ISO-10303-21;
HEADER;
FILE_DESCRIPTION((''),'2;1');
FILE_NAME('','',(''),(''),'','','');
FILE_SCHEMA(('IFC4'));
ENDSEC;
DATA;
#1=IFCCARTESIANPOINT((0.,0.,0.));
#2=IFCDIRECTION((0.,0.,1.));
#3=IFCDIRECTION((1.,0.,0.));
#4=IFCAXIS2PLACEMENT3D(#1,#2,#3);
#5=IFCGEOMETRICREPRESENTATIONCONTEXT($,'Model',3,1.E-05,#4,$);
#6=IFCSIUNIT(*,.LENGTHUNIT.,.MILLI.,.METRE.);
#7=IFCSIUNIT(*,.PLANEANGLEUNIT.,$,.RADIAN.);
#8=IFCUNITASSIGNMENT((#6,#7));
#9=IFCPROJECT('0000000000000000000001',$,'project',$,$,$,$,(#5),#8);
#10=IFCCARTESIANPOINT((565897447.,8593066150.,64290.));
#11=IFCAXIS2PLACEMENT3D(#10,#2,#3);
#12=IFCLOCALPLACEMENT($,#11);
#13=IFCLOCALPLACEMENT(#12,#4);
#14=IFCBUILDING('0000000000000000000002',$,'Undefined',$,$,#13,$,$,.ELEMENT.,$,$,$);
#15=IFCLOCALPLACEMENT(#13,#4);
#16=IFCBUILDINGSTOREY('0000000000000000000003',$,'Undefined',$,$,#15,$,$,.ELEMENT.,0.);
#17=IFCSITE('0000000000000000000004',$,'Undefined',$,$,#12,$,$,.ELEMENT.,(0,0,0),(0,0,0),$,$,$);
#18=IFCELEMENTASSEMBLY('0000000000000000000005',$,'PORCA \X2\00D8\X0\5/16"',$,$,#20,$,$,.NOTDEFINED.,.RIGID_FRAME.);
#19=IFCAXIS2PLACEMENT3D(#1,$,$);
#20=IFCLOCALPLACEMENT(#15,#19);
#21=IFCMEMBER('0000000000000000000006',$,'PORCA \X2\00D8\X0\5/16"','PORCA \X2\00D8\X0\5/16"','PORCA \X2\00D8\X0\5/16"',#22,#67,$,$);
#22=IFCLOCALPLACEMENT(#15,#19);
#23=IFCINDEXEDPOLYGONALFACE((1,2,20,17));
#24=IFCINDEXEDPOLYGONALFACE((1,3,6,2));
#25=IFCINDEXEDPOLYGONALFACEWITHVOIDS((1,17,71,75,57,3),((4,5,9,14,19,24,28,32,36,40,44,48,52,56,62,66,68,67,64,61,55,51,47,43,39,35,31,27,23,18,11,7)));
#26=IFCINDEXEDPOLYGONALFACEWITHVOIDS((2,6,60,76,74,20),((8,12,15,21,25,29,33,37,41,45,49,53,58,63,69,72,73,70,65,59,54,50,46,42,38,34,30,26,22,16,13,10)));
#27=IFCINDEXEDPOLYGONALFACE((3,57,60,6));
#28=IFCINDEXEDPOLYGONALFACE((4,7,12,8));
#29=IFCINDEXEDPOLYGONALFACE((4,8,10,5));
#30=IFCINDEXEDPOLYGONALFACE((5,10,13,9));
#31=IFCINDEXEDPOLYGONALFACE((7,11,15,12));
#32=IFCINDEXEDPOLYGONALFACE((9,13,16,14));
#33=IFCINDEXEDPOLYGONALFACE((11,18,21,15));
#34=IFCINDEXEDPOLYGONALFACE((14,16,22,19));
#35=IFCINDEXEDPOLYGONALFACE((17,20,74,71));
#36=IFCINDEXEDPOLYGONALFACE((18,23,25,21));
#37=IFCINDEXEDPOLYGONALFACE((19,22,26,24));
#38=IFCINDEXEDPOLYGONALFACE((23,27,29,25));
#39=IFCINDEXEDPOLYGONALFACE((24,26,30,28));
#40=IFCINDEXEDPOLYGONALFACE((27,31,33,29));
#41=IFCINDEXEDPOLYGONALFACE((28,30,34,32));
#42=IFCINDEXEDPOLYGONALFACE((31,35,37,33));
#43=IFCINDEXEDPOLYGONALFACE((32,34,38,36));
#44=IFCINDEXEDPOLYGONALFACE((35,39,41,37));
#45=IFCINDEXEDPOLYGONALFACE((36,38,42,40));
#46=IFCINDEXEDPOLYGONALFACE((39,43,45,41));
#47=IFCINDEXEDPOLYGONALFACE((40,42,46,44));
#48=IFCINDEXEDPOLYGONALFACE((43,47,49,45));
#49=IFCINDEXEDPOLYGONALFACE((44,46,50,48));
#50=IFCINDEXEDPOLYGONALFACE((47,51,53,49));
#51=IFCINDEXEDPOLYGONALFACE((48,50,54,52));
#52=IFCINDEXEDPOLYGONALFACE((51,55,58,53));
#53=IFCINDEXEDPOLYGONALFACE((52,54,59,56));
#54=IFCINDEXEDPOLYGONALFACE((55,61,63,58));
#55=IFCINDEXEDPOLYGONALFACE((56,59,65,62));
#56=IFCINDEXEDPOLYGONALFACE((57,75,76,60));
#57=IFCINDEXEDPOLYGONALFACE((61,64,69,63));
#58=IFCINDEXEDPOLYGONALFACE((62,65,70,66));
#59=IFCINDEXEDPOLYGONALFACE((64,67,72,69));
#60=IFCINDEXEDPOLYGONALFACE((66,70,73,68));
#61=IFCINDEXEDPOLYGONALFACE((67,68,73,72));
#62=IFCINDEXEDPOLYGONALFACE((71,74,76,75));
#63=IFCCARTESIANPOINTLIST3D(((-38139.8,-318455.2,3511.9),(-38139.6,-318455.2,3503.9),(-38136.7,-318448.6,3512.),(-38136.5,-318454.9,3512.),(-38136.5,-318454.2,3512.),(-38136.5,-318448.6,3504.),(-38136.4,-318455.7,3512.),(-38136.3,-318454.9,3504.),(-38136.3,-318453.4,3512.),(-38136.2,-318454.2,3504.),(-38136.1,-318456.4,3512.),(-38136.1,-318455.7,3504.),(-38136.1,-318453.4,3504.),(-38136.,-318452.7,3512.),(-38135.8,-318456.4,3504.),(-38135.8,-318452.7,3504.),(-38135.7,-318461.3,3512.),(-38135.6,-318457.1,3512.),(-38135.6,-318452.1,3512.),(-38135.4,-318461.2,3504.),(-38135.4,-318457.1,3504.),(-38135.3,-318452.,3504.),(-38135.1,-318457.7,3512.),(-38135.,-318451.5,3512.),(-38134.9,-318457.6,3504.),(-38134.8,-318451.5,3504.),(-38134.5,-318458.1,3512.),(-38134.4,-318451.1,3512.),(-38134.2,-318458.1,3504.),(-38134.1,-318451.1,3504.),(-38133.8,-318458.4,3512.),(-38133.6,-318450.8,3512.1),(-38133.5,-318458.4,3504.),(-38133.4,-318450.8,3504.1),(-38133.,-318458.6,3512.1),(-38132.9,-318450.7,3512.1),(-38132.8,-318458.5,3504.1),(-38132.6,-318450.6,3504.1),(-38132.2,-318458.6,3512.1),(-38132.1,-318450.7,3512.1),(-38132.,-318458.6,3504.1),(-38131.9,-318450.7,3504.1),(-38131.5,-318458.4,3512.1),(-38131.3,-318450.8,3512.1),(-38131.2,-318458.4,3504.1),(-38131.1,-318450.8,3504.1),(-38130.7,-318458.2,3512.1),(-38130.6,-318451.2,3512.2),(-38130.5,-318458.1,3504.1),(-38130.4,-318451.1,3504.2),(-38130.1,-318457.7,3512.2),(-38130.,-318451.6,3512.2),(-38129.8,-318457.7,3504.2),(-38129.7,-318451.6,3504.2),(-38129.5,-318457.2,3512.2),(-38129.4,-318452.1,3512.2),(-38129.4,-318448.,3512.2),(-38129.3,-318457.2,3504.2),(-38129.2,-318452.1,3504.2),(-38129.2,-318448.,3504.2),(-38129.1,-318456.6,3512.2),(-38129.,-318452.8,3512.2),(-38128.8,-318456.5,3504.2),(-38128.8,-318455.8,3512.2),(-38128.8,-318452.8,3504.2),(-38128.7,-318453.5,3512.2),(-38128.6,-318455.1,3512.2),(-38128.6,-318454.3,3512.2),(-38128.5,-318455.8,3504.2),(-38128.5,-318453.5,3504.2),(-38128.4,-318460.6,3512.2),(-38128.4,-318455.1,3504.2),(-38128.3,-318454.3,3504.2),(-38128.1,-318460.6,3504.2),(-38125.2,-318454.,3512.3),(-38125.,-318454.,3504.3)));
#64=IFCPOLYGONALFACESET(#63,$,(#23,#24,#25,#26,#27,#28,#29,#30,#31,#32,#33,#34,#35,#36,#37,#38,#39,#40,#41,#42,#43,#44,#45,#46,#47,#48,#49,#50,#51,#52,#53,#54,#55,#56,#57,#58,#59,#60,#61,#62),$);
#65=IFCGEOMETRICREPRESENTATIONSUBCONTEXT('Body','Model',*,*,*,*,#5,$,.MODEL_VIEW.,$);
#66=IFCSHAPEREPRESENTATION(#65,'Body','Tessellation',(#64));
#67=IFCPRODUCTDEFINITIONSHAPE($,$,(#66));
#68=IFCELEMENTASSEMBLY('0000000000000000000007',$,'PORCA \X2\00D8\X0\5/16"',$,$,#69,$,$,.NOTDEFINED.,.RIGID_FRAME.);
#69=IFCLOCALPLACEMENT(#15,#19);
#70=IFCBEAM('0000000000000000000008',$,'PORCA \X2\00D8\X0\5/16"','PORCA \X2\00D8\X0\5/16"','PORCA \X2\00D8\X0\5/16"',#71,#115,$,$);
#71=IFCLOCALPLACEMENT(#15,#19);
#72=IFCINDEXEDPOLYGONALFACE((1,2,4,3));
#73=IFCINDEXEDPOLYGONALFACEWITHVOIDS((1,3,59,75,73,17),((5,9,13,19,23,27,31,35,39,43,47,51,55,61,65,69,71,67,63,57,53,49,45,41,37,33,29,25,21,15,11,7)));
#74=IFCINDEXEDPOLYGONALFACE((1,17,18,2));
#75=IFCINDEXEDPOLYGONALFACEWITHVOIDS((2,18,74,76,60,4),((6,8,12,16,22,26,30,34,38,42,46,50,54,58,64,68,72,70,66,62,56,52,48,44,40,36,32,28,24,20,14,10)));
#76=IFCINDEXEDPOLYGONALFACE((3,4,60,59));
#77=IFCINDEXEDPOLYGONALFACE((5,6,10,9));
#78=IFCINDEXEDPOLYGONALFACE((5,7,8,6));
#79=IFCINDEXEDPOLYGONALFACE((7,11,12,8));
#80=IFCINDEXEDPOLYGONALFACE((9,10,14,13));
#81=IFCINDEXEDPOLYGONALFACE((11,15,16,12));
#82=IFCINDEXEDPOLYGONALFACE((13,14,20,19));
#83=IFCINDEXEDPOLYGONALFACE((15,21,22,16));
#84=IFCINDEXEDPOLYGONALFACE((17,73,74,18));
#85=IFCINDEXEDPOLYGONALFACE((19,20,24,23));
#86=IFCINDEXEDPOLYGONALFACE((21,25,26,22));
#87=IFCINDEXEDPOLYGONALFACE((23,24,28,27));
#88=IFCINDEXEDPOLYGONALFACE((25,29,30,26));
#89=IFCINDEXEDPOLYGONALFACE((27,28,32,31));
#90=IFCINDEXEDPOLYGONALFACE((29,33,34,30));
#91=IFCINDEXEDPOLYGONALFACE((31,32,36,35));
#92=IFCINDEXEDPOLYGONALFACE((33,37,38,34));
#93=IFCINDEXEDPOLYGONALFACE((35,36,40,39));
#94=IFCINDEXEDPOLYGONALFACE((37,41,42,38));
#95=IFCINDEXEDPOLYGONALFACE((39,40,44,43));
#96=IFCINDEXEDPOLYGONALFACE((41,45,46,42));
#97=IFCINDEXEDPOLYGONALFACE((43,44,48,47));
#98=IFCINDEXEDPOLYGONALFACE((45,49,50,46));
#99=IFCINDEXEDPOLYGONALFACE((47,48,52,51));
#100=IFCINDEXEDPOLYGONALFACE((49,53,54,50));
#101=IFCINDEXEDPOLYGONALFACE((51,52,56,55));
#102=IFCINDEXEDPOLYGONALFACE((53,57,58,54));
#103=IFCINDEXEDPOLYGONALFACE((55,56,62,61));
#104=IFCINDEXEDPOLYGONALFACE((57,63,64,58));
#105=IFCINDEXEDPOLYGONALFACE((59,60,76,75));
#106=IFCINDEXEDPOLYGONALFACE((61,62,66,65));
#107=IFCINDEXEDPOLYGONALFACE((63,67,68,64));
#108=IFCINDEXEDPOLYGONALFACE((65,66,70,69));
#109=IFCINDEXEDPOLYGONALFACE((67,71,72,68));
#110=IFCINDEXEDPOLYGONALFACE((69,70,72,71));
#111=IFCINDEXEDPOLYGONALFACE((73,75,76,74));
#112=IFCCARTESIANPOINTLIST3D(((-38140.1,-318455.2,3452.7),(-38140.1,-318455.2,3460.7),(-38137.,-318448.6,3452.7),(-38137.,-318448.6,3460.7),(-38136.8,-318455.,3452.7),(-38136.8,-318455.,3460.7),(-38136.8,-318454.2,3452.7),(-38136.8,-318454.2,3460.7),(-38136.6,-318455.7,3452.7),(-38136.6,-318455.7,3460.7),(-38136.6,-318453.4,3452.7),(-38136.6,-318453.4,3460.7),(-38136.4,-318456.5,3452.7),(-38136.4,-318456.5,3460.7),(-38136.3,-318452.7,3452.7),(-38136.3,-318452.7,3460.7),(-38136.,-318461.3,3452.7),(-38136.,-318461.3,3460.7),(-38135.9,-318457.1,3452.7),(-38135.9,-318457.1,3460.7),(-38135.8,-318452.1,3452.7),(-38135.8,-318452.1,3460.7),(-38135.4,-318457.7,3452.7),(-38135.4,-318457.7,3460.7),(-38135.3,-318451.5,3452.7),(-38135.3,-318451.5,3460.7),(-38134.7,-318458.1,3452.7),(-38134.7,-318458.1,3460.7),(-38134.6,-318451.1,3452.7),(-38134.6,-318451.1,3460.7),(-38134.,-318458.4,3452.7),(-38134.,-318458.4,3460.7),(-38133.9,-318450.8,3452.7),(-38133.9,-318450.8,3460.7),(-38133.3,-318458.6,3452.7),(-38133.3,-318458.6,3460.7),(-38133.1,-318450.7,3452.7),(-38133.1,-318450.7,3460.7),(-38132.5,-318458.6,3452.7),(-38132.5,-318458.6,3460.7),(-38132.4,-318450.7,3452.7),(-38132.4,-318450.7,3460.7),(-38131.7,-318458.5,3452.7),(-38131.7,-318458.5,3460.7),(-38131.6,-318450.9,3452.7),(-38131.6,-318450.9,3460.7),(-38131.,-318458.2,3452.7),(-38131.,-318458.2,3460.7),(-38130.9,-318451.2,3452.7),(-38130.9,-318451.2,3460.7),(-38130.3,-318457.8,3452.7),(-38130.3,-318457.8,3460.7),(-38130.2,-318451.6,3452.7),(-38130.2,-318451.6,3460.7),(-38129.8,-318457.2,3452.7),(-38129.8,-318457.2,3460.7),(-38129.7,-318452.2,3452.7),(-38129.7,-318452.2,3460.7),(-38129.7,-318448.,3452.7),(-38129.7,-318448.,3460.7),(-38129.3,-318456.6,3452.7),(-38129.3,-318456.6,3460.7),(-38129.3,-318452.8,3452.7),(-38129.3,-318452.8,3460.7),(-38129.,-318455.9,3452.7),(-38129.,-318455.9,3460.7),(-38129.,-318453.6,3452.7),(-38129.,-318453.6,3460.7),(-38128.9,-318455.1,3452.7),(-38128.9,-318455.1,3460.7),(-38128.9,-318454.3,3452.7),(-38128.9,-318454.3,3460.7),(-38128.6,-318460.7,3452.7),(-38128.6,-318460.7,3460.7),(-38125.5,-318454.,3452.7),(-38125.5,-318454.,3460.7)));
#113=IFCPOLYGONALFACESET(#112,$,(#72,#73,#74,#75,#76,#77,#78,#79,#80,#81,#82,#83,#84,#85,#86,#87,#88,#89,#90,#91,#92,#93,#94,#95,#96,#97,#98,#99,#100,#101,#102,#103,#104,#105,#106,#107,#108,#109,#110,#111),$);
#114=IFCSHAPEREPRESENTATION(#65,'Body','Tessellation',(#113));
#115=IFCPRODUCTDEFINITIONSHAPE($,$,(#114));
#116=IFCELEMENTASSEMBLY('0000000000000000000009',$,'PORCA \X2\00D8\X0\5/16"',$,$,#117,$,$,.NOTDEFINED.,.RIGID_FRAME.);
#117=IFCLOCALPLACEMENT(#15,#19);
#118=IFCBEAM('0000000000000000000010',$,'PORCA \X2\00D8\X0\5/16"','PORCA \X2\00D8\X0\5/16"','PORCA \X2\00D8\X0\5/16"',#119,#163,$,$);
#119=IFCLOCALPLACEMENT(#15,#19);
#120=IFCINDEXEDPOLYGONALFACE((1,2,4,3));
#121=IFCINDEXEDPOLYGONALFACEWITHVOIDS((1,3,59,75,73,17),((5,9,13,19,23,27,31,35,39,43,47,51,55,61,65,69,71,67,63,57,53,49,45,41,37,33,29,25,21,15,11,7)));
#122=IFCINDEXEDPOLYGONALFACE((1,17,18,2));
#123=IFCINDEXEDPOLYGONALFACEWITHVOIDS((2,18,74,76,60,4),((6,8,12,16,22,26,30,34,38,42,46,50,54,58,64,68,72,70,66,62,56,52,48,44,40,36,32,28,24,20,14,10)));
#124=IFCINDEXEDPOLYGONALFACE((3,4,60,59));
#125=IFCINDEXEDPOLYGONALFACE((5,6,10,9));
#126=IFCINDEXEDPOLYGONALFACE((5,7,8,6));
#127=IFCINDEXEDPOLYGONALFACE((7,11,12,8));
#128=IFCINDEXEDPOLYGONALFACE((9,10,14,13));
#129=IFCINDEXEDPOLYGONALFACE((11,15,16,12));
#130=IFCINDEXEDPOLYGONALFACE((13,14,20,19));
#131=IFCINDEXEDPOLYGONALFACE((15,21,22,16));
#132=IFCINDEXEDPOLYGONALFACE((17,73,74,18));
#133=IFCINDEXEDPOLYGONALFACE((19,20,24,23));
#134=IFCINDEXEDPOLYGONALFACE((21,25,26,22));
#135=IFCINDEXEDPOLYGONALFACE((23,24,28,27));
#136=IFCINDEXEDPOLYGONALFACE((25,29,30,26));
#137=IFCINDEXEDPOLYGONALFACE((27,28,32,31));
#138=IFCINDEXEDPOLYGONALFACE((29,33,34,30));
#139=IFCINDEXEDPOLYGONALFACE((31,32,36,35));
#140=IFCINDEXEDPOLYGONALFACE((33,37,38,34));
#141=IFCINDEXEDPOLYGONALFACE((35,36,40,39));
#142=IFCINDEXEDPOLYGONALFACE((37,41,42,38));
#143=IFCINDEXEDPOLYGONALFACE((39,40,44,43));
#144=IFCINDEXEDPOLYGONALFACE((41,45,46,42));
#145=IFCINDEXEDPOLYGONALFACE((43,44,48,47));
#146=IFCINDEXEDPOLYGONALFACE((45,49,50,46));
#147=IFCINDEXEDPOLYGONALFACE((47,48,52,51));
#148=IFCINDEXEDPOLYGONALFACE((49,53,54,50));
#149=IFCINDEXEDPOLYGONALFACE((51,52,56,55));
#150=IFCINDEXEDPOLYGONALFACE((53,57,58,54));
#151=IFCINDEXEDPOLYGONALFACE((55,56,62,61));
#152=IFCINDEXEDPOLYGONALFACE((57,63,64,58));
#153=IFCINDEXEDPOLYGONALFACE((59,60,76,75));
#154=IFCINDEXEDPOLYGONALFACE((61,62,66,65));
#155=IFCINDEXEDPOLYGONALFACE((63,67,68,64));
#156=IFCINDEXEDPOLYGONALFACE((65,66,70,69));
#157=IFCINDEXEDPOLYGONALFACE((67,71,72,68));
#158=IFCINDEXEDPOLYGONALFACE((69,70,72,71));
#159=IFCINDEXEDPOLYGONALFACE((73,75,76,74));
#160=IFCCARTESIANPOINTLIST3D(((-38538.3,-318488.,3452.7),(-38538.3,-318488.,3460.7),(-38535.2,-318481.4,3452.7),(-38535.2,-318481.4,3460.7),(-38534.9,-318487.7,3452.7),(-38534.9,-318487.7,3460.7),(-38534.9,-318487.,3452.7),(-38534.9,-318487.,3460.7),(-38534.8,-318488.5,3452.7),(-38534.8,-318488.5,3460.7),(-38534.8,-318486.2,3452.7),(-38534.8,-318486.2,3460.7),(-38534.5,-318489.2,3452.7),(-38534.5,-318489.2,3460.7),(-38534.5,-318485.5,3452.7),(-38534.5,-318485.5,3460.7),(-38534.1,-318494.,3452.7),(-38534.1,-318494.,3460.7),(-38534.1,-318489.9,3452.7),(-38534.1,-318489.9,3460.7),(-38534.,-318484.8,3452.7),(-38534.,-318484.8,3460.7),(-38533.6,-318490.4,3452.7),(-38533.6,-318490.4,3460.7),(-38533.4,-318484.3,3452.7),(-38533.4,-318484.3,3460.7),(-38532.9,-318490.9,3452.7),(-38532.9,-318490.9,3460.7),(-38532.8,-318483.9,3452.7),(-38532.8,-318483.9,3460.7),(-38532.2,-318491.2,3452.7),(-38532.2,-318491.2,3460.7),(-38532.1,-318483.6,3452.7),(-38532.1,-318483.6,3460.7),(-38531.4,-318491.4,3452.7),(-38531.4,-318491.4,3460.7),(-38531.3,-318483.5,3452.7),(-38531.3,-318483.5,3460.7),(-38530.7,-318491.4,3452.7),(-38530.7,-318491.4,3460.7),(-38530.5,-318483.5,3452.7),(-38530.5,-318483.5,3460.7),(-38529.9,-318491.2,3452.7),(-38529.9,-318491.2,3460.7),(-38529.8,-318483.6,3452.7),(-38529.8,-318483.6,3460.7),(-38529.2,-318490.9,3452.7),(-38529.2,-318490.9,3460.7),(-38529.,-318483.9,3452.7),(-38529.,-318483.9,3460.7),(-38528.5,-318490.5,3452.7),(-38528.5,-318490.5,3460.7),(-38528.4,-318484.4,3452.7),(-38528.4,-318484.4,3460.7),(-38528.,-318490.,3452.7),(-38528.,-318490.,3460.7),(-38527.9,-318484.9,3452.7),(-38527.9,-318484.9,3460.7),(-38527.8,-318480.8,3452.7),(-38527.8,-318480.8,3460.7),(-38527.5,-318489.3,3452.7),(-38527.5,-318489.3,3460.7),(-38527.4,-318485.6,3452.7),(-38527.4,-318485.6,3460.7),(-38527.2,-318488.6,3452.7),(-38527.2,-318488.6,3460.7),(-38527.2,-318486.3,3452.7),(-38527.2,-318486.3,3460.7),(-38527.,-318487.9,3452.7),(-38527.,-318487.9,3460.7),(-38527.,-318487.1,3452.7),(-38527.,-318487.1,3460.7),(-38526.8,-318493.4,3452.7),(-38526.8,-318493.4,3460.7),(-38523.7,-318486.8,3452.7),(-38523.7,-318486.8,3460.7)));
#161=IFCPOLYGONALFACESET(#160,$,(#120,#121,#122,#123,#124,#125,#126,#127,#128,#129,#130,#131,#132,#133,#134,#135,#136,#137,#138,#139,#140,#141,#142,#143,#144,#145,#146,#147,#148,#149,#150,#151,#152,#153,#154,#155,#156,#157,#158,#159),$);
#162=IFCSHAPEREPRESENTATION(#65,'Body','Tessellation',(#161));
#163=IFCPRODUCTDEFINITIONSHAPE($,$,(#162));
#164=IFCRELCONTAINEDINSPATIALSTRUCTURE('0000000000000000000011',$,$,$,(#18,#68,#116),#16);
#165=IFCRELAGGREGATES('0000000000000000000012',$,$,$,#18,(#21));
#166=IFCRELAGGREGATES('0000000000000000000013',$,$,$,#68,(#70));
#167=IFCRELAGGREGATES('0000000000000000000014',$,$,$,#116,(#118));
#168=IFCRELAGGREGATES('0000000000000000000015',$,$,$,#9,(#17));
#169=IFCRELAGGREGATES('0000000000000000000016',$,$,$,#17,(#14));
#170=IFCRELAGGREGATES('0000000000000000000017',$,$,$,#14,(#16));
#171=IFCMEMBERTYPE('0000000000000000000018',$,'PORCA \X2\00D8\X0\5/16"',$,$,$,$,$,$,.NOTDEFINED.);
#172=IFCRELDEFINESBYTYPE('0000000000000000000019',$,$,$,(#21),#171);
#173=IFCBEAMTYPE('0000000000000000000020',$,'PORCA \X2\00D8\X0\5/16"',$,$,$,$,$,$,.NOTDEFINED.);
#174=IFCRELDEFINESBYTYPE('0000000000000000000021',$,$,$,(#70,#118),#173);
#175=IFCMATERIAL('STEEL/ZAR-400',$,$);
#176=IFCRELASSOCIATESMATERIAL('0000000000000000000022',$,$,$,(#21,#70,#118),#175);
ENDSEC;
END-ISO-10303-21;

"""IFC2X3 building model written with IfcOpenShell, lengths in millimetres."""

from ifc_helpers import new_model, si_unit, frame, origin_with_axes, place, context, subcontext, project, spatial, polyline, outline, extrude, material, type_object, element, aggregate, save


model = new_model("IFC2X3")

# Units and contexts
model_context = context("Model", 3, precision=1e-05, world=origin_with_axes())
body_context = subcontext(model_context, "Body", "Model", "MODEL_VIEW")
ifc_project = project(units=[si_unit("LENGTHUNIT", "METRE", prefix="MILLI"), si_unit("PLANEANGLEUNIT", "RADIAN")], contexts=[model_context])

# Site, building, storey
site_placement = place(None, frame((565897447.0, 8593066150.0, 64290.0), z_axis=(0.0, 0.0, 1.0), x_axis=(1.0, 0.0, 0.0)))
site = spatial("IfcSite", under=ifc_project, at=site_placement, Name="Undefined", CompositionType="ELEMENT", RefLatitude=(0, 0, 0), RefLongitude=(0, 0, 0))
building_placement = place(site_placement, origin_with_axes())
building = spatial("IfcBuilding", under=site, at=building_placement, Name="Undefined", CompositionType="ELEMENT")
storey_placement = place(building_placement, origin_with_axes())
storey = spatial("IfcBuildingStorey", under=building, at=storey_placement, Name="Undefined", CompositionType="ELEMENT", Elevation=0.0)

# Element assembly, member
assembly_1_placement = place(storey_placement, origin_with_axes())
assembly_1 = element("IfcElementAssembly", 1, at=assembly_1_placement, inside=storey, Name="PORCA Ø5/16\"", AssemblyPlace="NOTDEFINED", PredefinedType="RIGID_FRAME")
ifc_material_1 = material(Name="STEEL/ZAR-400")
member_type = type_object("IfcMemberType", Name="PORCA Ø5/16\"", PredefinedType="NOTDEFINED")
member_placement = place(assembly_1_placement, frame((-38134.3, -318454.8, 3512.0), z_axis=(-0.082025, 0.99663, 0.0), x_axis=(0.029566, 0.002433, -0.99956)))
member = element("IfcMember", 2, at=member_placement, type_object=member_type, material=ifc_material_1, Name="PORCA Ø5/16\"", Description="PORCA Ø5/16\"", ObjectType="PORCA Ø5/16\"", context=body_context, shape_type="SweptSolid", body=[
    extrude(outline(polyline([(5.4, 6.3), (9.1, 0.0), (5.4, -6.3), (-2.0, -6.3), (-5.6, 0.0), (-2.0, 6.3), (5.4, 6.3)]), holes=[polyline([(0.2, -3.7), (0.9, -3.9), (1.7, -4.0), (2.5, -3.9), (3.2, -3.7), (3.9, -3.3), (4.5, -2.8), (5.0, -2.2), (5.4, -1.5), (5.6, -0.8), (5.7, 0.0), (5.6, 0.8), (5.4, 1.5), (5.0, 2.2), (4.5, 2.8), (3.9, 3.3), (3.2, 3.7), (2.5, 3.9), (1.7, 4.0), (0.9, 3.9), (0.2, 3.7), (-0.5, 3.3), (-1.1, 2.8), (-1.6, 2.2), (-2.0, 1.5), (-2.2, 0.8), (-2.2, 0.0), (-2.2, -0.8), (-2.0, -1.5), (-1.6, -2.2), (-1.1, -2.8), (-0.5, -3.3), (0.2, -3.7)])]), frame((8.0, 0.0, 0.0), z_axis=(-1.0, 0.0, 0.0), x_axis=(0.0, -1.0, 0.0)), (0.0, 0.0, 1.0), 8.0),
])
aggregate(assembly_1, [member])

# Element assemblies, beams
assembly_2_placement = place(storey_placement, origin_with_axes())
assembly_2 = element("IfcElementAssembly", 3, at=assembly_2_placement, inside=storey, Name="PORCA Ø5/16\"", AssemblyPlace="NOTDEFINED", PredefinedType="RIGID_FRAME")
beam_type_1 = type_object("IfcBeamType", Name="PORCA Ø5/16\"", PredefinedType="NOTDEFINED")
beam_1_placement = place(assembly_2_placement, frame((-38131.1, -318454.5, 3460.7), z_axis=(0.082025, -0.99663, 0.0), x_axis=(0.0, 0.0, -1.0)))
beam_1 = element("IfcBeam", 4, at=beam_1_placement, type_object=beam_type_1, material=ifc_material_1, Name="PORCA Ø5/16\"", Description="PORCA Ø5/16\"", ObjectType="PORCA Ø5/16\"", context=body_context, shape_type="SweptSolid", body=[
    extrude(outline(polyline([(5.4, 6.3), (9.1, 0.0), (5.4, -6.3), (-2.0, -6.3), (-5.6, 0.0), (-2.0, 6.3), (5.4, 6.3)]), holes=[polyline([(0.2, -3.7), (0.9, -3.9), (1.7, -4.0), (2.5, -3.9), (3.2, -3.7), (3.9, -3.3), (4.5, -2.8), (5.0, -2.2), (5.4, -1.5), (5.6, -0.8), (5.7, 0.0), (5.6, 0.8), (5.4, 1.5), (5.0, 2.2), (4.5, 2.8), (3.9, 3.3), (3.2, 3.7), (2.5, 3.9), (1.7, 4.0), (0.9, 3.9), (0.2, 3.7), (-0.5, 3.3), (-1.1, 2.8), (-1.6, 2.2), (-2.0, 1.5), (-2.2, 0.8), (-2.2, 0.0), (-2.2, -0.8), (-2.0, -1.5), (-1.6, -2.2), (-1.1, -2.8), (-0.5, -3.3), (0.2, -3.7)])]), frame((8.0, 0.0, 0.0), z_axis=(-1.0, 0.0, 0.0), x_axis=(0.0, -1.0, 0.0)), (0.0, 0.0, 1.0), 8.0),
])
aggregate(assembly_2, [beam_1])
assembly_3_placement = place(storey_placement, origin_with_axes())
assembly_3 = element("IfcElementAssembly", 5, at=assembly_3_placement, inside=storey, Name="PORCA Ø5/16\"", AssemblyPlace="NOTDEFINED", PredefinedType="RIGID_FRAME")
beam_2_placement = place(assembly_3_placement, frame((-38529.3, -318487.3, 3460.7), z_axis=(0.082025, -0.99663, 0.0), x_axis=(0.0, 0.0, -1.0)))
beam_2 = element("IfcBeam", 6, at=beam_2_placement, type_object=beam_type_1, material=ifc_material_1, Name="PORCA Ø5/16\"", Description="PORCA Ø5/16\"", ObjectType="PORCA Ø5/16\"", context=body_context, shape_type="SweptSolid", body=[
    extrude(outline(polyline([(5.4, 6.3), (9.1, 0.0), (5.4, -6.3), (-2.0, -6.3), (-5.6, 0.0), (-2.0, 6.3), (5.4, 6.3)]), holes=[polyline([(0.2, -3.7), (0.9, -3.9), (1.7, -4.0), (2.5, -3.9), (3.2, -3.7), (3.9, -3.3), (4.5, -2.8), (5.0, -2.2), (5.4, -1.5), (5.6, -0.8), (5.7, 0.0), (5.6, 0.8), (5.4, 1.5), (5.0, 2.2), (4.5, 2.8), (3.9, 3.3), (3.2, 3.7), (2.5, 3.9), (1.7, 4.0), (0.9, 3.9), (0.2, 3.7), (-0.5, 3.3), (-1.1, 2.8), (-1.6, 2.2), (-2.0, 1.5), (-2.2, 0.8), (-2.2, 0.0), (-2.2, -0.8), (-2.0, -1.5), (-1.6, -2.2), (-1.1, -2.8), (-0.5, -3.3), (0.2, -3.7)])]), frame((8.0, 0.0, 0.0), z_axis=(-1.0, 0.0, 0.0), x_axis=(0.0, -1.0, 0.0)), (0.0, 0.0, 1.0), 8.0),
])
aggregate(assembly_3, [beam_2])

save(model, "model.ifc")
